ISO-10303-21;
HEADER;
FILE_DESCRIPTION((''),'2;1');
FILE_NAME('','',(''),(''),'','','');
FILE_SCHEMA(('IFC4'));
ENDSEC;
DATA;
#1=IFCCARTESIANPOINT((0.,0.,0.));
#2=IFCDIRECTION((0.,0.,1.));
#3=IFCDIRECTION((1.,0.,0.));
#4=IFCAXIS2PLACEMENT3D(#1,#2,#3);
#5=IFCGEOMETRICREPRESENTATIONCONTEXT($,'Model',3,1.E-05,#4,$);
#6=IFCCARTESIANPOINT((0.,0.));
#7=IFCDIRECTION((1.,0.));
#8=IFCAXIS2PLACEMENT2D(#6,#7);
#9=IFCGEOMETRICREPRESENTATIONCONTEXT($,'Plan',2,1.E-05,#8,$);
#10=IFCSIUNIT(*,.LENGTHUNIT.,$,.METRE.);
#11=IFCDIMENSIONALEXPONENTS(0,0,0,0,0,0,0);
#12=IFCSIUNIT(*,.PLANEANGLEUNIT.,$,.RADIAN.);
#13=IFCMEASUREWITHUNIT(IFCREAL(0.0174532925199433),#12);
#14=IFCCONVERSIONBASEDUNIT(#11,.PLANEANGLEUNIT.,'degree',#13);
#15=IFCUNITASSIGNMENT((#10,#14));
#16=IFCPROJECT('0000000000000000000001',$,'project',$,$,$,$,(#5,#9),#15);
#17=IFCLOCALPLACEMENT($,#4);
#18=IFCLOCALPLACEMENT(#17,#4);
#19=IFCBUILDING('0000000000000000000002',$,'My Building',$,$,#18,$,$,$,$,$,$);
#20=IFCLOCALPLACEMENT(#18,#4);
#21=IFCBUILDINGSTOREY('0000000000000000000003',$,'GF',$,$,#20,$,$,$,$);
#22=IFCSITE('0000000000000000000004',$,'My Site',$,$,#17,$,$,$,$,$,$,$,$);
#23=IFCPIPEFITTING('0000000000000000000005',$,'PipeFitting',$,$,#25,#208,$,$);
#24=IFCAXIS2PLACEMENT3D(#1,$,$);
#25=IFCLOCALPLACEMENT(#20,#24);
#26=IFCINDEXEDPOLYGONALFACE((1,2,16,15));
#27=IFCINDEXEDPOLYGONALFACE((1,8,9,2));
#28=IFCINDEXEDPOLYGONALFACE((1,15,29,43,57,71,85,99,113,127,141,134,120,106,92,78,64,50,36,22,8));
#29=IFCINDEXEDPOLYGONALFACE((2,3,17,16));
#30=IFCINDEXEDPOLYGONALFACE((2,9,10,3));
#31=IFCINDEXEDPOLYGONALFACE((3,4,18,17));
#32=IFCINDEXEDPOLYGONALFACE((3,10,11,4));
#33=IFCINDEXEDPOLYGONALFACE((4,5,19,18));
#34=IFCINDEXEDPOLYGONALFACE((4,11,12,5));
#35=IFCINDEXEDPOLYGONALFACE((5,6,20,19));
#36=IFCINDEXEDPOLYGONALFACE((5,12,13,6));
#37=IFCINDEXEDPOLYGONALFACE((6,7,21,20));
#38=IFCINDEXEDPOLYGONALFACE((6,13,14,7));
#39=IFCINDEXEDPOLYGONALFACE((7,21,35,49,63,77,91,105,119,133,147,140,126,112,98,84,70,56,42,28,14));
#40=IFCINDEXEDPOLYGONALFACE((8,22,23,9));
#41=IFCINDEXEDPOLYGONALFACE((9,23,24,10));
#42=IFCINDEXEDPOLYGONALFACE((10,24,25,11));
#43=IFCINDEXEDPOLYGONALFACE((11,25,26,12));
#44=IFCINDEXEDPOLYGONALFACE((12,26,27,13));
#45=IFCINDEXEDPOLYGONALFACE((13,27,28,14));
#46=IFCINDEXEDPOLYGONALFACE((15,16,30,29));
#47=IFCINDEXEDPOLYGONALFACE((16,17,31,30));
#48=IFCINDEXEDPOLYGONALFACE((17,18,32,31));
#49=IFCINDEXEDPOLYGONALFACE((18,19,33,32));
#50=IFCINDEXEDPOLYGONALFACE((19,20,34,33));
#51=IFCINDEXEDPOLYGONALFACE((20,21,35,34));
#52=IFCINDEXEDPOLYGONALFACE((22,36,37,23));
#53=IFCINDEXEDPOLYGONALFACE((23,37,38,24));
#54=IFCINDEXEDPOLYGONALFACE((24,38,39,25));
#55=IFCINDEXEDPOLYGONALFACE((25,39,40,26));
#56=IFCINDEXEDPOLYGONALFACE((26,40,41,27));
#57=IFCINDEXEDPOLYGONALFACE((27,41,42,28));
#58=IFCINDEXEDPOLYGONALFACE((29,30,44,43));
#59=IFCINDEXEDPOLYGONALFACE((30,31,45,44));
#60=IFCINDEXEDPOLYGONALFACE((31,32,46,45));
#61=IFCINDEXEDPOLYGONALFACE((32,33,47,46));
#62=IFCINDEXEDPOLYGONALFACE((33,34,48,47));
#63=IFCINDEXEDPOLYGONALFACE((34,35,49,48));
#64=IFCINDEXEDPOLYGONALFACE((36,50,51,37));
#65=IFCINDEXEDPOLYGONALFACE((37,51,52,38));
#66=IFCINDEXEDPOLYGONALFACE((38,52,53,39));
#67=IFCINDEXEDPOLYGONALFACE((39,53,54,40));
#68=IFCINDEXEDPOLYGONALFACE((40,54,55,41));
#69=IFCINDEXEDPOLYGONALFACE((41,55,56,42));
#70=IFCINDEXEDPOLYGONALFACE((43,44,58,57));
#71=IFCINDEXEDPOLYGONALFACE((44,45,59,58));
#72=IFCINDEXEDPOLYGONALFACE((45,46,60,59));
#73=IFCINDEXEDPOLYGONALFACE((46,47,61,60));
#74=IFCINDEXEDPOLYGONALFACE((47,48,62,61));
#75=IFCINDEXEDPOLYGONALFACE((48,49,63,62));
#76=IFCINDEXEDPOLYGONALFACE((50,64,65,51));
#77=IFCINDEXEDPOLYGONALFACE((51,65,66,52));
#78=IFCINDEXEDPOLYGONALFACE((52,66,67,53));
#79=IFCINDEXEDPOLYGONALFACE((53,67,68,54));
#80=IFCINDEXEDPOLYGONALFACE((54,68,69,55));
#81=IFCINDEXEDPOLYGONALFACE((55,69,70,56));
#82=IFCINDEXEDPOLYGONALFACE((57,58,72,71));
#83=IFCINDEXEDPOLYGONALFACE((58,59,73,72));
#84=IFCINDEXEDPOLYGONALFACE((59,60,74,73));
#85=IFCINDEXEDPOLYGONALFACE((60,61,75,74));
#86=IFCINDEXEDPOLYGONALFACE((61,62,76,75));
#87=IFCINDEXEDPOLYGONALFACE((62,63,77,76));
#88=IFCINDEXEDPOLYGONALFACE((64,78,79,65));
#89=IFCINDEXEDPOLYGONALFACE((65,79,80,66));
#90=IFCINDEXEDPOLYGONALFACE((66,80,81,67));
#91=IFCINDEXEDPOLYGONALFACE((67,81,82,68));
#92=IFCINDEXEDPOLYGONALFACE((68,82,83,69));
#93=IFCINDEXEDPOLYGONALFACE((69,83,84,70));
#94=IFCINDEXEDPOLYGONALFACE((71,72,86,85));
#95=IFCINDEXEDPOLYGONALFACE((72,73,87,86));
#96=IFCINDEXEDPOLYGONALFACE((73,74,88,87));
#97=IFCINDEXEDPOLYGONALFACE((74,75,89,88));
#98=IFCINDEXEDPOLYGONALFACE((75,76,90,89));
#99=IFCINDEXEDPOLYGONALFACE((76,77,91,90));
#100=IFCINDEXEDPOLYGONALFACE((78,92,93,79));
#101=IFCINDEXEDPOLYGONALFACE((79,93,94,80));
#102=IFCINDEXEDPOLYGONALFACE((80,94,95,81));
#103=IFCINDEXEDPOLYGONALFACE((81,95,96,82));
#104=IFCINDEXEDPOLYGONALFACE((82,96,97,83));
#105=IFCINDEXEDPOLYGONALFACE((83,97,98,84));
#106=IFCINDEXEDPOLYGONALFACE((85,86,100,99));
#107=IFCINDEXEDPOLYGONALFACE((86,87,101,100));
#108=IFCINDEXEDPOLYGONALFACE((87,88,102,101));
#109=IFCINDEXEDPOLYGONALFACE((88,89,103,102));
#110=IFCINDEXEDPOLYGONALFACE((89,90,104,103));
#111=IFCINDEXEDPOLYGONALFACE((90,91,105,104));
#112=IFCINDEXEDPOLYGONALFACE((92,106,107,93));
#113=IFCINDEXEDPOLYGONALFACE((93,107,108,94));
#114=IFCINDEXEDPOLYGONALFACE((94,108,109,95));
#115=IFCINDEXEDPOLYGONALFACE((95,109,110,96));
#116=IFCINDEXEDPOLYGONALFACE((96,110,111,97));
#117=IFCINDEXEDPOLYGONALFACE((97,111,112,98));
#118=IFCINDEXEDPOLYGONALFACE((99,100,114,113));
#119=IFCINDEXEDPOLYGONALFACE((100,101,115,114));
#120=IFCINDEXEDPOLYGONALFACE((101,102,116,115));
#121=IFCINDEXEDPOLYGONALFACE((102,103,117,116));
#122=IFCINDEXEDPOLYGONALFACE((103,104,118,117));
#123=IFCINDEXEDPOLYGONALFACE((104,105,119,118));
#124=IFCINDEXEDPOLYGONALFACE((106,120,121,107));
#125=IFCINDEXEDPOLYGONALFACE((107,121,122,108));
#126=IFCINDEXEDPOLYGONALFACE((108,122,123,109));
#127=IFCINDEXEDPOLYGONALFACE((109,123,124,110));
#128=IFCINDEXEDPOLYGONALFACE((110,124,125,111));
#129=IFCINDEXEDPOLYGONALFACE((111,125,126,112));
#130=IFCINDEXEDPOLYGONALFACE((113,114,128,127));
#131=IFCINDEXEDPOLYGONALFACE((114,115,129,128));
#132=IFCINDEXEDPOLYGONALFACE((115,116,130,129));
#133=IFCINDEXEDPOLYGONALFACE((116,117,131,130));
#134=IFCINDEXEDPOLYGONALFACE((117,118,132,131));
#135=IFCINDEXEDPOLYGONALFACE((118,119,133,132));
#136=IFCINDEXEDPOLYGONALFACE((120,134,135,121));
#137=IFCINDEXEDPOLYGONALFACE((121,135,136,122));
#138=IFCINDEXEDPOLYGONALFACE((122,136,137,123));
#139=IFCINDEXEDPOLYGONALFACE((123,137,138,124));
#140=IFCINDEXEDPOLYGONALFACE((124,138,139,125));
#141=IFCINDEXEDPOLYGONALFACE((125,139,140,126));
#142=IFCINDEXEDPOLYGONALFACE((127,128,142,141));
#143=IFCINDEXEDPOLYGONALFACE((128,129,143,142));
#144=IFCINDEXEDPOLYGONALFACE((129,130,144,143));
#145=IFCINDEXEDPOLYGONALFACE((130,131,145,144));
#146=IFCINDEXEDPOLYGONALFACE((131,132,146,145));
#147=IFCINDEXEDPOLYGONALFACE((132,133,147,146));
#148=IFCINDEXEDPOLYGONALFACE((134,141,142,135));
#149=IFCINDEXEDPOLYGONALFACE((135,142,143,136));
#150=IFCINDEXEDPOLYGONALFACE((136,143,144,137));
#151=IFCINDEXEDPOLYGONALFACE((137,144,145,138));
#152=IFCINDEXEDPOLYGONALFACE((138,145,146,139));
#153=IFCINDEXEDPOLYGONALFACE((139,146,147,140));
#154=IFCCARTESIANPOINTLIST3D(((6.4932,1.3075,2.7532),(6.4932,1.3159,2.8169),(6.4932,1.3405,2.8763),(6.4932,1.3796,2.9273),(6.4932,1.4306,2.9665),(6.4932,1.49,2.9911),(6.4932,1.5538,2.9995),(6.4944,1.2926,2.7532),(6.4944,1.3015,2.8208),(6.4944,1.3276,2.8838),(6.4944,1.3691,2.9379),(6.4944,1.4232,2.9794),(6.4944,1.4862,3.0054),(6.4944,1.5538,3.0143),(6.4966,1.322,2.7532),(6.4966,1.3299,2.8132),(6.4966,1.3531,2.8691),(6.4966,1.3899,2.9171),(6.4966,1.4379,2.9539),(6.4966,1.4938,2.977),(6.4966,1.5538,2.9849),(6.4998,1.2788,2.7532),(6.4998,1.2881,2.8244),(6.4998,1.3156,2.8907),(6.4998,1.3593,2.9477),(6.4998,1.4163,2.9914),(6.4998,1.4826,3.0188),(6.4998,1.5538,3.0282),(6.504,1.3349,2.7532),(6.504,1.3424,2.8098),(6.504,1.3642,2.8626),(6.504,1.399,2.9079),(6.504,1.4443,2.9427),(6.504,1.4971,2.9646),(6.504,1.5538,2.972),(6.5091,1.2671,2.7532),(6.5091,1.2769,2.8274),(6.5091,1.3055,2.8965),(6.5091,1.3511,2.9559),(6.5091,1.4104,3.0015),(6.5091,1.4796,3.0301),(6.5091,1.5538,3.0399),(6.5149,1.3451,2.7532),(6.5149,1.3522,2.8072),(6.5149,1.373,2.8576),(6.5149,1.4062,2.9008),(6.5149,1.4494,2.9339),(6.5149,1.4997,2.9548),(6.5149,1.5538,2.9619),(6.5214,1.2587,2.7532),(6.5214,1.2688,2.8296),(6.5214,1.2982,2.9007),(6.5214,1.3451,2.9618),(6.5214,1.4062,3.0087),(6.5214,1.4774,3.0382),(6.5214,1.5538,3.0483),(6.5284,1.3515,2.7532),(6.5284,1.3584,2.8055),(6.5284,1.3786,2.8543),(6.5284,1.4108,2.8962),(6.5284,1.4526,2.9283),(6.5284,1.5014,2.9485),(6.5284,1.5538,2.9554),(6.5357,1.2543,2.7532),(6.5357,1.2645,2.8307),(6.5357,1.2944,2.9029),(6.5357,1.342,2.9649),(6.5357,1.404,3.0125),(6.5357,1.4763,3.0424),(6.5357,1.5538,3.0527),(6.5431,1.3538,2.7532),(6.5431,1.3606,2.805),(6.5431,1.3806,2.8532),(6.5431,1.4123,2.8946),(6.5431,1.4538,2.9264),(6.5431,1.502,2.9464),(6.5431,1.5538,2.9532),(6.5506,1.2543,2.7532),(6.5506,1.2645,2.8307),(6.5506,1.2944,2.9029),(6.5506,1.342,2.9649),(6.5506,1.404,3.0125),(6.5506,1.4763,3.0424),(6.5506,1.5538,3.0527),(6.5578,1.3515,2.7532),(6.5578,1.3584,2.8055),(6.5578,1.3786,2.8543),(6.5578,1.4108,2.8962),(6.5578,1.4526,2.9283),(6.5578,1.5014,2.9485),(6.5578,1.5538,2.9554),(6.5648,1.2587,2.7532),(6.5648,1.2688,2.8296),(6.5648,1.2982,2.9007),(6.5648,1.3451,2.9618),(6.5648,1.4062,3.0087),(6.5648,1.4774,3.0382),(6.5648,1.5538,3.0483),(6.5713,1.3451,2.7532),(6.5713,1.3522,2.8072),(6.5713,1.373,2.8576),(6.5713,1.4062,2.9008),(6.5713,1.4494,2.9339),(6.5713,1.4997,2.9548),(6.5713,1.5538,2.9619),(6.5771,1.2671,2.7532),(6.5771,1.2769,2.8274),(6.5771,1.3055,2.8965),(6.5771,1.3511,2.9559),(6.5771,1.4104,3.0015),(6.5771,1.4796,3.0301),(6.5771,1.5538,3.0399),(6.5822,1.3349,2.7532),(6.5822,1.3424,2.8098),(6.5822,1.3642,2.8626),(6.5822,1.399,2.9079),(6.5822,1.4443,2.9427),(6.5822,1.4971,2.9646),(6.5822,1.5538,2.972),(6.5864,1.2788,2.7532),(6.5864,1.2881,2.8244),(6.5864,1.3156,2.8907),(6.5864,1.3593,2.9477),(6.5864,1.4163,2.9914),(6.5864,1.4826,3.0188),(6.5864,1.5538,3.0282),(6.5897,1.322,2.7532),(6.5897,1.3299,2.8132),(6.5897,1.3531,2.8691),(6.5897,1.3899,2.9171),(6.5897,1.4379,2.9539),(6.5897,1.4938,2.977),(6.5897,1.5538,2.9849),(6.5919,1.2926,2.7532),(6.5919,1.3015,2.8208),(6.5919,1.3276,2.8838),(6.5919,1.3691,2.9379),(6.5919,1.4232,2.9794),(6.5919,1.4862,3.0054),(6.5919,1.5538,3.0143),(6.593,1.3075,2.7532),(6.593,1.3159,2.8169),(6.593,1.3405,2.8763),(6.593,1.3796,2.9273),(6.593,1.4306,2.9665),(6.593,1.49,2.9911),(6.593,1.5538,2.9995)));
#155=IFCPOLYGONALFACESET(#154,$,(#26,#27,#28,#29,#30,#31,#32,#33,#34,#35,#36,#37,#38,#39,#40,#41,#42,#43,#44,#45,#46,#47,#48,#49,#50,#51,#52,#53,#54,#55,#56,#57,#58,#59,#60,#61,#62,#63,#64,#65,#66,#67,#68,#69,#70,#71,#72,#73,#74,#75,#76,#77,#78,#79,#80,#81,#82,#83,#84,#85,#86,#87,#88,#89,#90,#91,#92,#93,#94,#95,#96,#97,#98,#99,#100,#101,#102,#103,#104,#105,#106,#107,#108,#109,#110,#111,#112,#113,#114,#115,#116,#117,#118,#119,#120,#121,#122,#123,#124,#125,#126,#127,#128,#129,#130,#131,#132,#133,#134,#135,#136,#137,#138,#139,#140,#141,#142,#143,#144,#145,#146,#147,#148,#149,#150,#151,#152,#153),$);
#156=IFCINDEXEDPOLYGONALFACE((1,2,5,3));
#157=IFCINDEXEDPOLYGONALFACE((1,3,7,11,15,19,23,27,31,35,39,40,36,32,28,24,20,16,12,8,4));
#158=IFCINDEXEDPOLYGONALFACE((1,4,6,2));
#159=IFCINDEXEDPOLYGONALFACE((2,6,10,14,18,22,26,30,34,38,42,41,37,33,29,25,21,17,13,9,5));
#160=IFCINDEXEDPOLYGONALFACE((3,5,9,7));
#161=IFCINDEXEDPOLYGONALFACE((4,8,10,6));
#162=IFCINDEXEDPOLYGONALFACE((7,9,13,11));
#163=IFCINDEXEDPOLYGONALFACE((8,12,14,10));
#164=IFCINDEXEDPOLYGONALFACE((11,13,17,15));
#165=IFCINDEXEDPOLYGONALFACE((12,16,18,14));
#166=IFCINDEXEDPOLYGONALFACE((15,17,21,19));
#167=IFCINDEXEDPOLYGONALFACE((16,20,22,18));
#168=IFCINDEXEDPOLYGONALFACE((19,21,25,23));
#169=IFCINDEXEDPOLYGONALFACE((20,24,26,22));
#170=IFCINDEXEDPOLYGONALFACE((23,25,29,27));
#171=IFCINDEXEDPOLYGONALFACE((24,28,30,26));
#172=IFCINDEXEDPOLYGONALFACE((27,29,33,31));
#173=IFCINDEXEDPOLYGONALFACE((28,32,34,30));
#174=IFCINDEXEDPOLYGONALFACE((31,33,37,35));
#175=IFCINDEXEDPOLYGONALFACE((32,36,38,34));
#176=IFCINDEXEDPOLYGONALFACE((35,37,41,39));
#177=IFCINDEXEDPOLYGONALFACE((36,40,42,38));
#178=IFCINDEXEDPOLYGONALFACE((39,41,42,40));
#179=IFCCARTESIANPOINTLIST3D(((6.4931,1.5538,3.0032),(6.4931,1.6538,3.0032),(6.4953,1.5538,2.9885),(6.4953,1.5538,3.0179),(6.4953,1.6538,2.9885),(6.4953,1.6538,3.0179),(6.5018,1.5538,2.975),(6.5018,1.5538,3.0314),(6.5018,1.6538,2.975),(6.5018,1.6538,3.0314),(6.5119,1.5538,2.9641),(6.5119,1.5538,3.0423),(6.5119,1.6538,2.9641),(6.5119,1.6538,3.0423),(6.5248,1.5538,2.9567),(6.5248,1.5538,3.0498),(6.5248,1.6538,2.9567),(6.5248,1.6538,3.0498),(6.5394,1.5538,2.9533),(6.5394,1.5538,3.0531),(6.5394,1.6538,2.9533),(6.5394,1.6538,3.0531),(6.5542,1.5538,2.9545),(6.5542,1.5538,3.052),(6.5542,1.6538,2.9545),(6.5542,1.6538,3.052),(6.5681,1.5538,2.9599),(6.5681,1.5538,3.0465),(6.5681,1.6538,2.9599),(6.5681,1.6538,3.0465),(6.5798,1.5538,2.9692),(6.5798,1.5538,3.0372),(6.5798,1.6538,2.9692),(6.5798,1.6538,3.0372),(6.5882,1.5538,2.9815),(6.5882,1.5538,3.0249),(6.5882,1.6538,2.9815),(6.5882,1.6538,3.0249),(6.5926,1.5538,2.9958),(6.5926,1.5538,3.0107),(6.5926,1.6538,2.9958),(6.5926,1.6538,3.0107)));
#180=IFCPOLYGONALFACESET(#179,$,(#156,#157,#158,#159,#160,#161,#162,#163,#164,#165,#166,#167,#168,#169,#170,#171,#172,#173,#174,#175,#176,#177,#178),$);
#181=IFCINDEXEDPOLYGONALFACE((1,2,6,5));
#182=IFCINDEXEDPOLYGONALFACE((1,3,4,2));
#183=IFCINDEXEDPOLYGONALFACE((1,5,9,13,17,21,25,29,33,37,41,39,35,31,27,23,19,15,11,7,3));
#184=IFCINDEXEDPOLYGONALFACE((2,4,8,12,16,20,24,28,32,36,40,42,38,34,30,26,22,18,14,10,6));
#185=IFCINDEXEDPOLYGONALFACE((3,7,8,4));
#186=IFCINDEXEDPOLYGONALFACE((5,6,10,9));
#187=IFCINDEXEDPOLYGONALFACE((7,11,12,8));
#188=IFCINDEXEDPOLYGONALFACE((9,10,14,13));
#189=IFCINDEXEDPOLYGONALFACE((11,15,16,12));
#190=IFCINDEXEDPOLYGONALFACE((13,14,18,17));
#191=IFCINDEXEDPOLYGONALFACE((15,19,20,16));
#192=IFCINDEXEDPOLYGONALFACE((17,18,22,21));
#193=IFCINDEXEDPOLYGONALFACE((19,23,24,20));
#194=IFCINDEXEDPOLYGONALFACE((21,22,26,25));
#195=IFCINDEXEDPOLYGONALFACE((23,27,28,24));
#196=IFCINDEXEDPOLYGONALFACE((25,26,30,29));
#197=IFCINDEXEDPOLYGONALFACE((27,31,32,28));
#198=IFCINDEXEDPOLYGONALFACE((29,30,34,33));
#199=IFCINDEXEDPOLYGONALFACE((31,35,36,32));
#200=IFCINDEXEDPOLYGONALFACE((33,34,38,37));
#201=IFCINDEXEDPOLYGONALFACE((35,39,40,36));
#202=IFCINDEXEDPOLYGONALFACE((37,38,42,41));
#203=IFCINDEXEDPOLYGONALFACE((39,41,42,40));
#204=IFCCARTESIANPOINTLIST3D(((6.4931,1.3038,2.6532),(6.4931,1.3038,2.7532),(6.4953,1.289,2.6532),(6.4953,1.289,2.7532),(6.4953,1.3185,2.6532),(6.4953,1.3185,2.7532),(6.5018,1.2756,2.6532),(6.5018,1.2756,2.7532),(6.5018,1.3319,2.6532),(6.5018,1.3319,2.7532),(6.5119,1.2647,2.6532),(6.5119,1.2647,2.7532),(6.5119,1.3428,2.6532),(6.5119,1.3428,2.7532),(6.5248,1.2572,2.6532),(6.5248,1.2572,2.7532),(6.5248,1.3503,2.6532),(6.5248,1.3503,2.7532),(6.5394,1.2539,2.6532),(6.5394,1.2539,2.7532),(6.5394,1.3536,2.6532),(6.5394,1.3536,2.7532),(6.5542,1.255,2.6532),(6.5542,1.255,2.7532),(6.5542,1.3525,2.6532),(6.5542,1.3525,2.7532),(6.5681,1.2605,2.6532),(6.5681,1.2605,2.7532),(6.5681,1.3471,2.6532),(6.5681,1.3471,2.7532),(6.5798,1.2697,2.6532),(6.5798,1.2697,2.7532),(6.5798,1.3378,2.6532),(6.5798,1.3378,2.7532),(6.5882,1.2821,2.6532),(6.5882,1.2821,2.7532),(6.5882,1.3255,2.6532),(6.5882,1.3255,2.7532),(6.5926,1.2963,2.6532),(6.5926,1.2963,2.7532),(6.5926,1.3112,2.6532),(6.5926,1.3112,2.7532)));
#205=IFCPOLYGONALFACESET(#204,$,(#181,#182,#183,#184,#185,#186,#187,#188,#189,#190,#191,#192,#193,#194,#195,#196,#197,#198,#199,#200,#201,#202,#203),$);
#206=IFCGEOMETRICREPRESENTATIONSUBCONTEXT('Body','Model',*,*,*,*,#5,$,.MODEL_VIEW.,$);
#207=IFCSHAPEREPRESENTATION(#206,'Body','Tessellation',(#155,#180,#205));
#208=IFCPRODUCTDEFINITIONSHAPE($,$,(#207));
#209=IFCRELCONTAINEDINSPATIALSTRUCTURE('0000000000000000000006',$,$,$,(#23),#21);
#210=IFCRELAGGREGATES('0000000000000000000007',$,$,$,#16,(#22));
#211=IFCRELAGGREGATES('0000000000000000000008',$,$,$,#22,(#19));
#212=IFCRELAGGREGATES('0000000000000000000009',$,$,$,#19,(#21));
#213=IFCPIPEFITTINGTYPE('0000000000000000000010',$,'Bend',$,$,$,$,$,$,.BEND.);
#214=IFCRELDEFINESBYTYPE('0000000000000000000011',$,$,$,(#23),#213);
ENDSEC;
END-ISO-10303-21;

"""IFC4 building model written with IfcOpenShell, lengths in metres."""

from ifc_helpers import new_model, entity, si_unit, converted_unit, frame, origin_with_axes, origin_2d_with_axis, place, context, subcontext, project, spatial, circle, extrude, source, transform, mapped, type_object, type_shapes, element, save


model = new_model("IFC4")

# Units and contexts
model_context = context("Model", 3, precision=1e-05, world=origin_with_axes())
plan_context = context("Plan", 2, precision=1e-05, world=origin_2d_with_axis())
body_context_1 = subcontext(model_context, "Body", "Model", "MODEL_VIEW")
ifc_project = project(units=[si_unit("LENGTHUNIT", "METRE"), converted_unit("PLANEANGLEUNIT", "degree", entity("IfcReal", 0.0174532925199433), si_unit("PLANEANGLEUNIT", "RADIAN"), dimensions=[0, 0, 0, 0, 0, 0, 0])], contexts=[model_context, plan_context])

# Site, building, storey
site_placement = place(None, origin_with_axes())
site = spatial("IfcSite", under=ifc_project, at=site_placement, Name="My Site")
building_placement = place(site_placement, origin_with_axes())
building = spatial("IfcBuilding", under=site, at=building_placement, Name="My Building")
storey_placement = place(building_placement, origin_with_axes())
storey = spatial("IfcBuildingStorey", under=building, at=storey_placement, Name="GF")

# Shared definitions
pipe_fitting_type = type_object("IfcPipeFittingType", Name="Bend", PredefinedType="BEND")
shared_shape_1 = source(origin_with_axes(), body_context_1, "Body", "SolidModel", [
    entity("IfcSweptDiskSolid", entity("IfcIndexedPolyCurve", entity("IfcCartesianPointList3D", [[0.0, 0.0, -0.1], [0.0, -0.0732, -0.2768], [0.0, -0.25, -0.35]]), [entity("IfcArcIndex", [1, 2, 3])]), 0.05),
    extrude(circle(Radius=0.05), origin_with_axes(), (0.0, 0.0, -1.0), 0.1),
    extrude(circle(Radius=0.05), frame((0.0, -0.25, -0.35), z_axis=(0.0, -1.0, 0.0), x_axis=(1.0, 0.0, 0.0)), (0.0, 0.0, 1.0), 0.1),
])
type_shapes(pipe_fitting_type, [shared_shape_1])

# Pipe fitting
for number, where, z_axis, x_axis, name in (
    (1, (6.5431, 1.6538, 3.0032), (0.0, 1.0, 0.0), (-1.0, 0.0, 0.0), "PipeFitting"),
):
    element("IfcPipeFitting", number, at=place(storey_placement, frame(where, z_axis=z_axis, x_axis=x_axis)), inside=storey, type_object=pipe_fitting_type, Name=name, context=body_context_1, shape_type="MappedRepresentation", body=[
        mapped(shared_shape_1, transform((0.0, 0.0, 0.0), x_axis=(1.0, 0.0, 0.0), y_axis=(0.0, 1.0, 0.0), z_axis=(0.0, 0.0, 1.0), scale=1.0)),
    ])

save(model, "model.ifc")
